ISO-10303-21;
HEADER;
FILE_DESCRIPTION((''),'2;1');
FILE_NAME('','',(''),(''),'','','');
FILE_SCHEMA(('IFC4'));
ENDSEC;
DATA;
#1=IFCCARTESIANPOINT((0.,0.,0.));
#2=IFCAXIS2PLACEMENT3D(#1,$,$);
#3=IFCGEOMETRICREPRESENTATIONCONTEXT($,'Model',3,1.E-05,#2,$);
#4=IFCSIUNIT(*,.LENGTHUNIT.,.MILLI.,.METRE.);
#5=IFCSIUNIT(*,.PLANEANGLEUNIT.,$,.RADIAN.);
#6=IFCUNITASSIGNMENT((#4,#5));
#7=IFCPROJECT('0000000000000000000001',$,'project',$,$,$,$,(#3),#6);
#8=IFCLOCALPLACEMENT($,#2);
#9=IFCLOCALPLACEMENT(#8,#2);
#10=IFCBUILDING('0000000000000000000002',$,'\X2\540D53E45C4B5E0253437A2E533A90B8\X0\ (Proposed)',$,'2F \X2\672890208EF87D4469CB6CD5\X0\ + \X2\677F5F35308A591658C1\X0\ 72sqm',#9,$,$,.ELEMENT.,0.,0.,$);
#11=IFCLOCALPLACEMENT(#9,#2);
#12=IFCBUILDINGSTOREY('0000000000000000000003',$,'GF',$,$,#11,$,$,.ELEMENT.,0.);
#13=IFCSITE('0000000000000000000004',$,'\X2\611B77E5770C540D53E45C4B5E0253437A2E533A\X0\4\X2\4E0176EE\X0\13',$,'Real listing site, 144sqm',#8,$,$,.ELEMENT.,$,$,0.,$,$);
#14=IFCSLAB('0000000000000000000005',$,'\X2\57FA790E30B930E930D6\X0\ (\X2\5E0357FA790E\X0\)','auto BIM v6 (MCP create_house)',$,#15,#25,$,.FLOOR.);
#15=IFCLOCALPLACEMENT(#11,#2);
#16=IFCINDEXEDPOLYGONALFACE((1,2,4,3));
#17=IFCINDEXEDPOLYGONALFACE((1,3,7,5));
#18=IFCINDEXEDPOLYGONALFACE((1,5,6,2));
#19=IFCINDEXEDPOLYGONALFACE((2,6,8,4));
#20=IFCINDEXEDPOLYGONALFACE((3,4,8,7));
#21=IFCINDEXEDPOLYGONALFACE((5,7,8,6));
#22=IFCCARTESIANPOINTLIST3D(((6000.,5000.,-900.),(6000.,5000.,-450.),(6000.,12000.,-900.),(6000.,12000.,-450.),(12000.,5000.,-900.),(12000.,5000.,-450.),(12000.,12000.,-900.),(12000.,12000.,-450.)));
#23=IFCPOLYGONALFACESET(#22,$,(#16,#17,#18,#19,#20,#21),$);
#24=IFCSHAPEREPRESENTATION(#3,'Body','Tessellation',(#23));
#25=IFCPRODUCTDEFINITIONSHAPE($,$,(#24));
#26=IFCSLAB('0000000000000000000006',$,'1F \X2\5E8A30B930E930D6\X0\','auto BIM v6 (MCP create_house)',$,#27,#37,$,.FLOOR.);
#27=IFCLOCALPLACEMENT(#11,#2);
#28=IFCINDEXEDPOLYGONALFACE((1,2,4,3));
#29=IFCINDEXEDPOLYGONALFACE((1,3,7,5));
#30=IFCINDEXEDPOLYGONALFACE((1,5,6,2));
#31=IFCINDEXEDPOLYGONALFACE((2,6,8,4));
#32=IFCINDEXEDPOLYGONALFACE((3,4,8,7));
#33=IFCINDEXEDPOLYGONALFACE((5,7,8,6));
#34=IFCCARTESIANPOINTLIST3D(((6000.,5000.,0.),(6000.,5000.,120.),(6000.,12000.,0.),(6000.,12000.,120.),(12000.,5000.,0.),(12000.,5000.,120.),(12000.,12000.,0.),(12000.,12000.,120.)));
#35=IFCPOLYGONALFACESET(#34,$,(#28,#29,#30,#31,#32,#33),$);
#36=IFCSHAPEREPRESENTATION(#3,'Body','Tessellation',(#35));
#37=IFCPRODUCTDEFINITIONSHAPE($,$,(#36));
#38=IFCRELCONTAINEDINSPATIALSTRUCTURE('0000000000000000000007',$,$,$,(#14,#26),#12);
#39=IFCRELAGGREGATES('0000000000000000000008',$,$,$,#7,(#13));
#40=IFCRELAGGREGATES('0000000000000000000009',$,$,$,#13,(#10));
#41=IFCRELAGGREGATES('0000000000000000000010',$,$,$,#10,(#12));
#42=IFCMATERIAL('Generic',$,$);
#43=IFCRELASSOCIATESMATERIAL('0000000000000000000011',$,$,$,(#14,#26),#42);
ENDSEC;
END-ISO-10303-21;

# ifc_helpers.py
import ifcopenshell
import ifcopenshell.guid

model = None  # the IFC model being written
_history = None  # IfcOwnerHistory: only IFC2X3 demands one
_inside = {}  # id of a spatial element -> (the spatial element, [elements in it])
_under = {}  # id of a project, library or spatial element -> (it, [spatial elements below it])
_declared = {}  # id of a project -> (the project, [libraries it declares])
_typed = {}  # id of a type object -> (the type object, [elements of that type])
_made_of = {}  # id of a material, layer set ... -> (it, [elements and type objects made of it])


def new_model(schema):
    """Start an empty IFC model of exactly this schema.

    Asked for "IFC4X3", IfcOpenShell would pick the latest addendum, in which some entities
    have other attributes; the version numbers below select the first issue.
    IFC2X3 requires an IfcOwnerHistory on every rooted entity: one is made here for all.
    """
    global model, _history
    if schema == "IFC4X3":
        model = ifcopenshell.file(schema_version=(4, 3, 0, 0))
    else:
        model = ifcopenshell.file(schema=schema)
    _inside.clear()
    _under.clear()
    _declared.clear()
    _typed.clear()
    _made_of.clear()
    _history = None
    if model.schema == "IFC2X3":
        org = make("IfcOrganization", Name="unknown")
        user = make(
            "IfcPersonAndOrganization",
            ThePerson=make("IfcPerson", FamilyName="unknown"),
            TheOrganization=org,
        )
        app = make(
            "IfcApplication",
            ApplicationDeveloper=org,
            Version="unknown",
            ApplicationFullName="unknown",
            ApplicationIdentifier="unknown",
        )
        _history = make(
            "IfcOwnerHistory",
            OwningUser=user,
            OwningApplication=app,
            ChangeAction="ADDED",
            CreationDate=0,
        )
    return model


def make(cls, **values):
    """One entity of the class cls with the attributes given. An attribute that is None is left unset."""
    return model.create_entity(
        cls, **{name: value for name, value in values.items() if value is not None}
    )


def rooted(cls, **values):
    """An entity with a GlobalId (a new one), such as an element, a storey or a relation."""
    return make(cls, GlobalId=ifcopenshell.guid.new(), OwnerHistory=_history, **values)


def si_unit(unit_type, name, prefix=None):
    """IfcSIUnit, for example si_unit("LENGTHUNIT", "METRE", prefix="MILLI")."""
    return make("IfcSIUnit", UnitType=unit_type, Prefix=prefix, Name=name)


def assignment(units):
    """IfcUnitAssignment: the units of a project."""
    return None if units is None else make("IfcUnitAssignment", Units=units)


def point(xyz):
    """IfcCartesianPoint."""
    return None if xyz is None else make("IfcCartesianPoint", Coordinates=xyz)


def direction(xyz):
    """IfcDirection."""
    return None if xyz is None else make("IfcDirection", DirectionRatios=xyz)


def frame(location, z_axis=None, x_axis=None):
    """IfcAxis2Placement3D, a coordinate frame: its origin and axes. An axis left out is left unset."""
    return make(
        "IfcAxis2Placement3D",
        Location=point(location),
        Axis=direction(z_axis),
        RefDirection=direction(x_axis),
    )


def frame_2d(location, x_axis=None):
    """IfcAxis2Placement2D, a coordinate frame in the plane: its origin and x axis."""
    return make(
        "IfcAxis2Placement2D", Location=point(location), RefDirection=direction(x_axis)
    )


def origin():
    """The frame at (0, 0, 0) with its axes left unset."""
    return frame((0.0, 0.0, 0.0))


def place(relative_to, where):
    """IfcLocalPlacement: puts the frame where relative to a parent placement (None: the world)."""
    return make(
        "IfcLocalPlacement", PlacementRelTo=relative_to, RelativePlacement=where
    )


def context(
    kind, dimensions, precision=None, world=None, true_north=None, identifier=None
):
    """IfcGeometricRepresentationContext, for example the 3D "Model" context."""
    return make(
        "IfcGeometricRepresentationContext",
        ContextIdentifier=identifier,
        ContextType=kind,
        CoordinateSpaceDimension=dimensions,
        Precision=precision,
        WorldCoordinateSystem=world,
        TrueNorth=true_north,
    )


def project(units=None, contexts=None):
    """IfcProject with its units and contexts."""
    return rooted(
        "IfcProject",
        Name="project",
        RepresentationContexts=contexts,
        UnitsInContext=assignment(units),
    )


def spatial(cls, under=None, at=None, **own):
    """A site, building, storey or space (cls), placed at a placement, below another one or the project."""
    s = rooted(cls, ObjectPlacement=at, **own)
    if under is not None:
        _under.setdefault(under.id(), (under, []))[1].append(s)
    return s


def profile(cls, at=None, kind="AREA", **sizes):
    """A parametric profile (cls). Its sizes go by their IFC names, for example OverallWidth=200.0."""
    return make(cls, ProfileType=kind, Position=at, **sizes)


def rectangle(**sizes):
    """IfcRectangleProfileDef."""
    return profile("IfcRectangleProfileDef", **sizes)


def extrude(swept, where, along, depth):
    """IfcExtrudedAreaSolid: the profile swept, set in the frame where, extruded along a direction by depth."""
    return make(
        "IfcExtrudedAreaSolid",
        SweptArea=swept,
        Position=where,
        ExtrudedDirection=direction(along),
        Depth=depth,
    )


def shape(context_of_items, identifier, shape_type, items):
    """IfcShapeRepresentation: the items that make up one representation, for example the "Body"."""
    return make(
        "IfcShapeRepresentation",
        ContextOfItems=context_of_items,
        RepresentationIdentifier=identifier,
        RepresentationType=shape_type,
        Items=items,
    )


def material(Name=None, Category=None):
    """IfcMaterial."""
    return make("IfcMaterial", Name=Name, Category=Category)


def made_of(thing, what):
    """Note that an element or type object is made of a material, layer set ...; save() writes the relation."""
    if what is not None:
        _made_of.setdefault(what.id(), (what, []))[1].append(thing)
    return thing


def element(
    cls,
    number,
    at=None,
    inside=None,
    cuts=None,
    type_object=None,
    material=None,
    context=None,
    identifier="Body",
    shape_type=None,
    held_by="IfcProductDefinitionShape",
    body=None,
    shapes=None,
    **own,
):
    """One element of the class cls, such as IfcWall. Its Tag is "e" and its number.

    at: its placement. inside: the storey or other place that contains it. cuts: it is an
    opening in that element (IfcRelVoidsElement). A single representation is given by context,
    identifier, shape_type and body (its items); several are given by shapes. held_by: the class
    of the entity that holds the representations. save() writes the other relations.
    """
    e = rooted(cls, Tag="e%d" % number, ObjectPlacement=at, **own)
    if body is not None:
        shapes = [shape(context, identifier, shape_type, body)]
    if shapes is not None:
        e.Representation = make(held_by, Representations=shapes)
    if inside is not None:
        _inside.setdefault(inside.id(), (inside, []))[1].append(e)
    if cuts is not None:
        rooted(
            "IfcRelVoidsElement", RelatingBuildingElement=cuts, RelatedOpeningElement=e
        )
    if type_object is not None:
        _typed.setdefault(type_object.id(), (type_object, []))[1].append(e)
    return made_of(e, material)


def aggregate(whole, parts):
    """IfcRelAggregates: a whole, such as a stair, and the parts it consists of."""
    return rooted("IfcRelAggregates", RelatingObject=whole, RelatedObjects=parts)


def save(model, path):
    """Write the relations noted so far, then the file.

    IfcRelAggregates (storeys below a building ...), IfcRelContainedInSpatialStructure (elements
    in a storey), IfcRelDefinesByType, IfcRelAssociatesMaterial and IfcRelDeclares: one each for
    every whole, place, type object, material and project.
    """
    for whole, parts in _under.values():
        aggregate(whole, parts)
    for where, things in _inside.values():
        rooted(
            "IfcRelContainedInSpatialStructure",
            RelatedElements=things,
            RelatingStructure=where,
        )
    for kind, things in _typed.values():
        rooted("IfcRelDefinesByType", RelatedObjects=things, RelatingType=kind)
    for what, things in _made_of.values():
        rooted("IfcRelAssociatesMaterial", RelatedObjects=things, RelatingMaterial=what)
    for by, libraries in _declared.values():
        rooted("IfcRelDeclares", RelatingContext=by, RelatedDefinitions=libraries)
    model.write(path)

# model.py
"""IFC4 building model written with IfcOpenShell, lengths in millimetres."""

from ifc_helpers import new_model, si_unit, frame, frame_2d, origin, place, context, project, spatial, rectangle, extrude, material, element, save


model = new_model("IFC4")

# Units and contexts
model_context = context("Model", 3, precision=1e-05, world=origin())
ifc_project = project(units=[si_unit("LENGTHUNIT", "METRE", prefix="MILLI"), si_unit("PLANEANGLEUNIT", "RADIAN")], contexts=[model_context])

# Site, building, storey
site_placement = place(None, origin())
site = spatial("IfcSite", under=ifc_project, at=site_placement, Name="愛知県名古屋市千種区4丁目13", ObjectType="Real listing site, 144sqm", CompositionType="ELEMENT", RefElevation=0.0)
building_placement = place(site_placement, origin())
building = spatial("IfcBuilding", under=site, at=building_placement, Name="名古屋市千種区邸 (Proposed)", ObjectType="2F 木造軸組構法 + 板張り外壁 72sqm", CompositionType="ELEMENT", ElevationOfRefHeight=0.0, ElevationOfTerrain=0.0)
storey_placement = place(building_placement, origin())
storey = spatial("IfcBuildingStorey", under=building, at=storey_placement, Name="GF", CompositionType="ELEMENT", Elevation=0.0)

# Slabs
ifc_material = material(Name="Generic")
slab_1_placement = place(storey_placement, frame((3000.0, 2500.0, -450.0)))
element("IfcSlab", 1, at=slab_1_placement, inside=storey, material=ifc_material, Name="基礎スラブ (布基礎)", Description="auto BIM v6 (MCP create_house)", PredefinedType="FLOOR", context=model_context, shape_type="SweptSolid", body=[
    extrude(rectangle(XDim=6000.0, YDim=7000.0, at=frame_2d((3000.0, 3500.0))), frame((3000.0, 2500.0, -450.0)), (0.0, 0.0, 1.0), 450.0),
])
slab_2_placement = place(storey_placement, frame((3000.0, 2500.0, 0.0)))
element("IfcSlab", 2, at=slab_2_placement, inside=storey, material=ifc_material, Name="1F 床スラブ", Description="auto BIM v6 (MCP create_house)", PredefinedType="FLOOR", context=model_context, shape_type="SweptSolid", body=[
    extrude(rectangle(XDim=6000.0, YDim=7000.0, at=frame_2d((3000.0, 3500.0))), frame((3000.0, 2500.0, 0.0)), (0.0, 0.0, 1.0), 120.0),
])

save(model, "model.ifc")
